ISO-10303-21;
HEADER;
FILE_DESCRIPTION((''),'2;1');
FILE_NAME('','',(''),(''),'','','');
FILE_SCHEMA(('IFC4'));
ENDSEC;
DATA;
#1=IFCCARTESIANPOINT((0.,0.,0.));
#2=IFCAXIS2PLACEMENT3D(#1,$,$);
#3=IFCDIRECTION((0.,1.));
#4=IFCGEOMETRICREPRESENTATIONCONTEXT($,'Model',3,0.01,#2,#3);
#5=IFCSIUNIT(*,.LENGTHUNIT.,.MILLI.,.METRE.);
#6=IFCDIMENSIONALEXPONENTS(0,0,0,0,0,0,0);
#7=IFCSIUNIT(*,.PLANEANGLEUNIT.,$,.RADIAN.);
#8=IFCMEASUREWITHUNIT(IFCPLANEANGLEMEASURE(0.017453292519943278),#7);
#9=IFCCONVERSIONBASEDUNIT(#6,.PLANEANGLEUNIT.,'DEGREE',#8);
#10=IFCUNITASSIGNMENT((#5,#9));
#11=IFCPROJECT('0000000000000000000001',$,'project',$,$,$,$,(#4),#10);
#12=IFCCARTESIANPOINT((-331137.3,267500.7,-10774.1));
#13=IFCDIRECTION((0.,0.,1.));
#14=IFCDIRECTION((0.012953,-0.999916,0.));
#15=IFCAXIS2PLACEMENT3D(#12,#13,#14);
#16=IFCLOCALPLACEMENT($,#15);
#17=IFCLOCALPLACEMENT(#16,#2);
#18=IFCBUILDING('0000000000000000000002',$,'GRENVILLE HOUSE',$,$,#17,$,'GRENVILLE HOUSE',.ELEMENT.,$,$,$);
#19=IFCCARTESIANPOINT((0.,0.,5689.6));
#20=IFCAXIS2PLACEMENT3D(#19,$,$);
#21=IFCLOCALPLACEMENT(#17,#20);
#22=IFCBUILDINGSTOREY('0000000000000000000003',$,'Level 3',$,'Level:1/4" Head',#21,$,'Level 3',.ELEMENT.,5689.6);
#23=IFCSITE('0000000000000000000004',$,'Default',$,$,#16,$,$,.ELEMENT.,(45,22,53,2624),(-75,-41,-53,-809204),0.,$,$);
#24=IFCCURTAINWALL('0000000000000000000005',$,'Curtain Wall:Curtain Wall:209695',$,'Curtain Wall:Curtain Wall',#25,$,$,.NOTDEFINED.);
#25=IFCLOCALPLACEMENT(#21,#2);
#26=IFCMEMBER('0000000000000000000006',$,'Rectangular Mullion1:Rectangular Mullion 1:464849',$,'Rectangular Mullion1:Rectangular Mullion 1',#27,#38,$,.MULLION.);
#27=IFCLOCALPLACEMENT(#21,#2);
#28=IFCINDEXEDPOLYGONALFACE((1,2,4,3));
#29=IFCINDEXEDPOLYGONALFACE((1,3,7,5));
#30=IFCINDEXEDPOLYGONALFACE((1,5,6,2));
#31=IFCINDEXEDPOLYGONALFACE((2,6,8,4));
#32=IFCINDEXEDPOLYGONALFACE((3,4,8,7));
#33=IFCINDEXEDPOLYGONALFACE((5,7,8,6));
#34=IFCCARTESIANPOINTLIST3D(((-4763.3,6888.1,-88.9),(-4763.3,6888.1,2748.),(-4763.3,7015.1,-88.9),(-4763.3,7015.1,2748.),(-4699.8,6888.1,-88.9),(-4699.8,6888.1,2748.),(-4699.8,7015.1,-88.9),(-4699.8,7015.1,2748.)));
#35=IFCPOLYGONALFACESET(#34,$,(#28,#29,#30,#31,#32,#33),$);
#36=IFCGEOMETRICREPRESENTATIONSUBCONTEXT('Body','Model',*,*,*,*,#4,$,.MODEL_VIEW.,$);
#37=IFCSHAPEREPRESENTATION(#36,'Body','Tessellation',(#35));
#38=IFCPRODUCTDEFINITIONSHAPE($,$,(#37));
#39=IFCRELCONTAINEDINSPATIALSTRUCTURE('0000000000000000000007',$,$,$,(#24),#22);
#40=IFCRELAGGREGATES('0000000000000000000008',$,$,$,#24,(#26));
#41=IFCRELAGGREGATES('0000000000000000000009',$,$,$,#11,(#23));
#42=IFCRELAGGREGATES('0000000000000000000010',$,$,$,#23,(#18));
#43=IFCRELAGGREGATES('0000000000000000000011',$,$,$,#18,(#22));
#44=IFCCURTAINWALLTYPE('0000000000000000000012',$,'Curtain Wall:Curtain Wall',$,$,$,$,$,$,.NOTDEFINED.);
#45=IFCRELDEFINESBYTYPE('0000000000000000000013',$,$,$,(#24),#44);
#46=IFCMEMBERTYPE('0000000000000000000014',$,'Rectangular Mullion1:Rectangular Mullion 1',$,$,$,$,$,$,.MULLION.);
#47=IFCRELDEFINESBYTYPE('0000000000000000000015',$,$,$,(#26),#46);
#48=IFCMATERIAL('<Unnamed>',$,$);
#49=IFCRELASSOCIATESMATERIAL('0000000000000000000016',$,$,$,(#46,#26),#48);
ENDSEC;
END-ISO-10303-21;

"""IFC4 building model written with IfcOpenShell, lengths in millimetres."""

from ifc_helpers import new_model, entity, si_unit, converted_unit, direction, frame, origin, place, context, subcontext, project, spatial, indexed_curve, outline, extrude, source, transform, mapped, material, type_object, type_shapes, element, aggregate, save


model = new_model("IFC4")

# Units and contexts
model_context = context("Model", 3, precision=0.01, world=origin(), true_north=direction((0.0, 1.0)))
body_context = subcontext(model_context, "Body", "Model", "MODEL_VIEW")
ifc_project = project(units=[si_unit("LENGTHUNIT", "METRE", prefix="MILLI"), converted_unit("PLANEANGLEUNIT", "DEGREE", entity("IfcPlaneAngleMeasure", 0.017453292519943278), si_unit("PLANEANGLEUNIT", "RADIAN"), dimensions=[0, 0, 0, 0, 0, 0, 0])], contexts=[model_context])

# Site, building, storey
site_placement = place(None, frame((-331137.3, 267500.7, -10774.1), z_axis=(0.0, 0.0, 1.0), x_axis=(0.012953, -0.999916, 0.0)))
site = spatial("IfcSite", under=ifc_project, at=site_placement, Name="Default", CompositionType="ELEMENT", RefLatitude=(45, 22, 53, 2624), RefLongitude=(-75, -41, -53, -809204), RefElevation=0.0)
building_placement = place(site_placement, origin())
building = spatial("IfcBuilding", under=site, at=building_placement, Name="GRENVILLE HOUSE", LongName="GRENVILLE HOUSE", CompositionType="ELEMENT")
storey_placement = place(building_placement, frame((0.0, 0.0, 5689.6)))
storey = spatial("IfcBuildingStorey", under=building, at=storey_placement, Name="Level 3", ObjectType="Level:1/4\" Head", LongName="Level 3", CompositionType="ELEMENT", Elevation=5689.6)

# Shared definitions
ifc_material_1 = material(Name="<Unnamed>")

# Curtain wall, member
curtain_wall_type = type_object("IfcCurtainWallType", Name="Curtain Wall:Curtain Wall", PredefinedType="NOTDEFINED")
curtain_wall_placement = place(storey_placement, frame((0.0, 0.0, -5689.6)))
curtain_wall = element("IfcCurtainWall", 1, at=curtain_wall_placement, inside=storey, type_object=curtain_wall_type, Name="Curtain Wall:Curtain Wall:209695", ObjectType="Curtain Wall:Curtain Wall", PredefinedType="NOTDEFINED")
member_type = type_object("IfcMemberType", Name="Rectangular Mullion1:Rectangular Mullion 1", PredefinedType="MULLION", material=ifc_material_1)
shared_shape_1 = source(origin(), body_context, "Body", "SweptSolid", [
    extrude(outline(indexed_curve([(-31.8, -63.5), (31.8, -63.5), (31.8, 63.5), (-31.8, 63.5), (-31.8, -63.5)], self_intersect=False)), frame((-31.8, 0.0, -2836.9), z_axis=(0.0, 0.0, 1.0), x_axis=(-1.0, 0.0, 0.0)), (0.0, 0.0, 1.0), 2836.9),
])
type_shapes(member_type, [shared_shape_1])
member_placement = place(curtain_wall_placement, frame((-4699.8, 6951.6, 8437.6)))
member = element("IfcMember", 2, at=member_placement, type_object=member_type, material=ifc_material_1, Name="Rectangular Mullion1:Rectangular Mullion 1:464849", ObjectType="Rectangular Mullion1:Rectangular Mullion 1", PredefinedType="MULLION", context=body_context, shape_type="MappedRepresentation", body=[
    mapped(shared_shape_1, transform((0.0, 0.0, 0.0), scale=1.0)),
])

aggregate(curtain_wall, [member])

save(model, "model.ifc")
